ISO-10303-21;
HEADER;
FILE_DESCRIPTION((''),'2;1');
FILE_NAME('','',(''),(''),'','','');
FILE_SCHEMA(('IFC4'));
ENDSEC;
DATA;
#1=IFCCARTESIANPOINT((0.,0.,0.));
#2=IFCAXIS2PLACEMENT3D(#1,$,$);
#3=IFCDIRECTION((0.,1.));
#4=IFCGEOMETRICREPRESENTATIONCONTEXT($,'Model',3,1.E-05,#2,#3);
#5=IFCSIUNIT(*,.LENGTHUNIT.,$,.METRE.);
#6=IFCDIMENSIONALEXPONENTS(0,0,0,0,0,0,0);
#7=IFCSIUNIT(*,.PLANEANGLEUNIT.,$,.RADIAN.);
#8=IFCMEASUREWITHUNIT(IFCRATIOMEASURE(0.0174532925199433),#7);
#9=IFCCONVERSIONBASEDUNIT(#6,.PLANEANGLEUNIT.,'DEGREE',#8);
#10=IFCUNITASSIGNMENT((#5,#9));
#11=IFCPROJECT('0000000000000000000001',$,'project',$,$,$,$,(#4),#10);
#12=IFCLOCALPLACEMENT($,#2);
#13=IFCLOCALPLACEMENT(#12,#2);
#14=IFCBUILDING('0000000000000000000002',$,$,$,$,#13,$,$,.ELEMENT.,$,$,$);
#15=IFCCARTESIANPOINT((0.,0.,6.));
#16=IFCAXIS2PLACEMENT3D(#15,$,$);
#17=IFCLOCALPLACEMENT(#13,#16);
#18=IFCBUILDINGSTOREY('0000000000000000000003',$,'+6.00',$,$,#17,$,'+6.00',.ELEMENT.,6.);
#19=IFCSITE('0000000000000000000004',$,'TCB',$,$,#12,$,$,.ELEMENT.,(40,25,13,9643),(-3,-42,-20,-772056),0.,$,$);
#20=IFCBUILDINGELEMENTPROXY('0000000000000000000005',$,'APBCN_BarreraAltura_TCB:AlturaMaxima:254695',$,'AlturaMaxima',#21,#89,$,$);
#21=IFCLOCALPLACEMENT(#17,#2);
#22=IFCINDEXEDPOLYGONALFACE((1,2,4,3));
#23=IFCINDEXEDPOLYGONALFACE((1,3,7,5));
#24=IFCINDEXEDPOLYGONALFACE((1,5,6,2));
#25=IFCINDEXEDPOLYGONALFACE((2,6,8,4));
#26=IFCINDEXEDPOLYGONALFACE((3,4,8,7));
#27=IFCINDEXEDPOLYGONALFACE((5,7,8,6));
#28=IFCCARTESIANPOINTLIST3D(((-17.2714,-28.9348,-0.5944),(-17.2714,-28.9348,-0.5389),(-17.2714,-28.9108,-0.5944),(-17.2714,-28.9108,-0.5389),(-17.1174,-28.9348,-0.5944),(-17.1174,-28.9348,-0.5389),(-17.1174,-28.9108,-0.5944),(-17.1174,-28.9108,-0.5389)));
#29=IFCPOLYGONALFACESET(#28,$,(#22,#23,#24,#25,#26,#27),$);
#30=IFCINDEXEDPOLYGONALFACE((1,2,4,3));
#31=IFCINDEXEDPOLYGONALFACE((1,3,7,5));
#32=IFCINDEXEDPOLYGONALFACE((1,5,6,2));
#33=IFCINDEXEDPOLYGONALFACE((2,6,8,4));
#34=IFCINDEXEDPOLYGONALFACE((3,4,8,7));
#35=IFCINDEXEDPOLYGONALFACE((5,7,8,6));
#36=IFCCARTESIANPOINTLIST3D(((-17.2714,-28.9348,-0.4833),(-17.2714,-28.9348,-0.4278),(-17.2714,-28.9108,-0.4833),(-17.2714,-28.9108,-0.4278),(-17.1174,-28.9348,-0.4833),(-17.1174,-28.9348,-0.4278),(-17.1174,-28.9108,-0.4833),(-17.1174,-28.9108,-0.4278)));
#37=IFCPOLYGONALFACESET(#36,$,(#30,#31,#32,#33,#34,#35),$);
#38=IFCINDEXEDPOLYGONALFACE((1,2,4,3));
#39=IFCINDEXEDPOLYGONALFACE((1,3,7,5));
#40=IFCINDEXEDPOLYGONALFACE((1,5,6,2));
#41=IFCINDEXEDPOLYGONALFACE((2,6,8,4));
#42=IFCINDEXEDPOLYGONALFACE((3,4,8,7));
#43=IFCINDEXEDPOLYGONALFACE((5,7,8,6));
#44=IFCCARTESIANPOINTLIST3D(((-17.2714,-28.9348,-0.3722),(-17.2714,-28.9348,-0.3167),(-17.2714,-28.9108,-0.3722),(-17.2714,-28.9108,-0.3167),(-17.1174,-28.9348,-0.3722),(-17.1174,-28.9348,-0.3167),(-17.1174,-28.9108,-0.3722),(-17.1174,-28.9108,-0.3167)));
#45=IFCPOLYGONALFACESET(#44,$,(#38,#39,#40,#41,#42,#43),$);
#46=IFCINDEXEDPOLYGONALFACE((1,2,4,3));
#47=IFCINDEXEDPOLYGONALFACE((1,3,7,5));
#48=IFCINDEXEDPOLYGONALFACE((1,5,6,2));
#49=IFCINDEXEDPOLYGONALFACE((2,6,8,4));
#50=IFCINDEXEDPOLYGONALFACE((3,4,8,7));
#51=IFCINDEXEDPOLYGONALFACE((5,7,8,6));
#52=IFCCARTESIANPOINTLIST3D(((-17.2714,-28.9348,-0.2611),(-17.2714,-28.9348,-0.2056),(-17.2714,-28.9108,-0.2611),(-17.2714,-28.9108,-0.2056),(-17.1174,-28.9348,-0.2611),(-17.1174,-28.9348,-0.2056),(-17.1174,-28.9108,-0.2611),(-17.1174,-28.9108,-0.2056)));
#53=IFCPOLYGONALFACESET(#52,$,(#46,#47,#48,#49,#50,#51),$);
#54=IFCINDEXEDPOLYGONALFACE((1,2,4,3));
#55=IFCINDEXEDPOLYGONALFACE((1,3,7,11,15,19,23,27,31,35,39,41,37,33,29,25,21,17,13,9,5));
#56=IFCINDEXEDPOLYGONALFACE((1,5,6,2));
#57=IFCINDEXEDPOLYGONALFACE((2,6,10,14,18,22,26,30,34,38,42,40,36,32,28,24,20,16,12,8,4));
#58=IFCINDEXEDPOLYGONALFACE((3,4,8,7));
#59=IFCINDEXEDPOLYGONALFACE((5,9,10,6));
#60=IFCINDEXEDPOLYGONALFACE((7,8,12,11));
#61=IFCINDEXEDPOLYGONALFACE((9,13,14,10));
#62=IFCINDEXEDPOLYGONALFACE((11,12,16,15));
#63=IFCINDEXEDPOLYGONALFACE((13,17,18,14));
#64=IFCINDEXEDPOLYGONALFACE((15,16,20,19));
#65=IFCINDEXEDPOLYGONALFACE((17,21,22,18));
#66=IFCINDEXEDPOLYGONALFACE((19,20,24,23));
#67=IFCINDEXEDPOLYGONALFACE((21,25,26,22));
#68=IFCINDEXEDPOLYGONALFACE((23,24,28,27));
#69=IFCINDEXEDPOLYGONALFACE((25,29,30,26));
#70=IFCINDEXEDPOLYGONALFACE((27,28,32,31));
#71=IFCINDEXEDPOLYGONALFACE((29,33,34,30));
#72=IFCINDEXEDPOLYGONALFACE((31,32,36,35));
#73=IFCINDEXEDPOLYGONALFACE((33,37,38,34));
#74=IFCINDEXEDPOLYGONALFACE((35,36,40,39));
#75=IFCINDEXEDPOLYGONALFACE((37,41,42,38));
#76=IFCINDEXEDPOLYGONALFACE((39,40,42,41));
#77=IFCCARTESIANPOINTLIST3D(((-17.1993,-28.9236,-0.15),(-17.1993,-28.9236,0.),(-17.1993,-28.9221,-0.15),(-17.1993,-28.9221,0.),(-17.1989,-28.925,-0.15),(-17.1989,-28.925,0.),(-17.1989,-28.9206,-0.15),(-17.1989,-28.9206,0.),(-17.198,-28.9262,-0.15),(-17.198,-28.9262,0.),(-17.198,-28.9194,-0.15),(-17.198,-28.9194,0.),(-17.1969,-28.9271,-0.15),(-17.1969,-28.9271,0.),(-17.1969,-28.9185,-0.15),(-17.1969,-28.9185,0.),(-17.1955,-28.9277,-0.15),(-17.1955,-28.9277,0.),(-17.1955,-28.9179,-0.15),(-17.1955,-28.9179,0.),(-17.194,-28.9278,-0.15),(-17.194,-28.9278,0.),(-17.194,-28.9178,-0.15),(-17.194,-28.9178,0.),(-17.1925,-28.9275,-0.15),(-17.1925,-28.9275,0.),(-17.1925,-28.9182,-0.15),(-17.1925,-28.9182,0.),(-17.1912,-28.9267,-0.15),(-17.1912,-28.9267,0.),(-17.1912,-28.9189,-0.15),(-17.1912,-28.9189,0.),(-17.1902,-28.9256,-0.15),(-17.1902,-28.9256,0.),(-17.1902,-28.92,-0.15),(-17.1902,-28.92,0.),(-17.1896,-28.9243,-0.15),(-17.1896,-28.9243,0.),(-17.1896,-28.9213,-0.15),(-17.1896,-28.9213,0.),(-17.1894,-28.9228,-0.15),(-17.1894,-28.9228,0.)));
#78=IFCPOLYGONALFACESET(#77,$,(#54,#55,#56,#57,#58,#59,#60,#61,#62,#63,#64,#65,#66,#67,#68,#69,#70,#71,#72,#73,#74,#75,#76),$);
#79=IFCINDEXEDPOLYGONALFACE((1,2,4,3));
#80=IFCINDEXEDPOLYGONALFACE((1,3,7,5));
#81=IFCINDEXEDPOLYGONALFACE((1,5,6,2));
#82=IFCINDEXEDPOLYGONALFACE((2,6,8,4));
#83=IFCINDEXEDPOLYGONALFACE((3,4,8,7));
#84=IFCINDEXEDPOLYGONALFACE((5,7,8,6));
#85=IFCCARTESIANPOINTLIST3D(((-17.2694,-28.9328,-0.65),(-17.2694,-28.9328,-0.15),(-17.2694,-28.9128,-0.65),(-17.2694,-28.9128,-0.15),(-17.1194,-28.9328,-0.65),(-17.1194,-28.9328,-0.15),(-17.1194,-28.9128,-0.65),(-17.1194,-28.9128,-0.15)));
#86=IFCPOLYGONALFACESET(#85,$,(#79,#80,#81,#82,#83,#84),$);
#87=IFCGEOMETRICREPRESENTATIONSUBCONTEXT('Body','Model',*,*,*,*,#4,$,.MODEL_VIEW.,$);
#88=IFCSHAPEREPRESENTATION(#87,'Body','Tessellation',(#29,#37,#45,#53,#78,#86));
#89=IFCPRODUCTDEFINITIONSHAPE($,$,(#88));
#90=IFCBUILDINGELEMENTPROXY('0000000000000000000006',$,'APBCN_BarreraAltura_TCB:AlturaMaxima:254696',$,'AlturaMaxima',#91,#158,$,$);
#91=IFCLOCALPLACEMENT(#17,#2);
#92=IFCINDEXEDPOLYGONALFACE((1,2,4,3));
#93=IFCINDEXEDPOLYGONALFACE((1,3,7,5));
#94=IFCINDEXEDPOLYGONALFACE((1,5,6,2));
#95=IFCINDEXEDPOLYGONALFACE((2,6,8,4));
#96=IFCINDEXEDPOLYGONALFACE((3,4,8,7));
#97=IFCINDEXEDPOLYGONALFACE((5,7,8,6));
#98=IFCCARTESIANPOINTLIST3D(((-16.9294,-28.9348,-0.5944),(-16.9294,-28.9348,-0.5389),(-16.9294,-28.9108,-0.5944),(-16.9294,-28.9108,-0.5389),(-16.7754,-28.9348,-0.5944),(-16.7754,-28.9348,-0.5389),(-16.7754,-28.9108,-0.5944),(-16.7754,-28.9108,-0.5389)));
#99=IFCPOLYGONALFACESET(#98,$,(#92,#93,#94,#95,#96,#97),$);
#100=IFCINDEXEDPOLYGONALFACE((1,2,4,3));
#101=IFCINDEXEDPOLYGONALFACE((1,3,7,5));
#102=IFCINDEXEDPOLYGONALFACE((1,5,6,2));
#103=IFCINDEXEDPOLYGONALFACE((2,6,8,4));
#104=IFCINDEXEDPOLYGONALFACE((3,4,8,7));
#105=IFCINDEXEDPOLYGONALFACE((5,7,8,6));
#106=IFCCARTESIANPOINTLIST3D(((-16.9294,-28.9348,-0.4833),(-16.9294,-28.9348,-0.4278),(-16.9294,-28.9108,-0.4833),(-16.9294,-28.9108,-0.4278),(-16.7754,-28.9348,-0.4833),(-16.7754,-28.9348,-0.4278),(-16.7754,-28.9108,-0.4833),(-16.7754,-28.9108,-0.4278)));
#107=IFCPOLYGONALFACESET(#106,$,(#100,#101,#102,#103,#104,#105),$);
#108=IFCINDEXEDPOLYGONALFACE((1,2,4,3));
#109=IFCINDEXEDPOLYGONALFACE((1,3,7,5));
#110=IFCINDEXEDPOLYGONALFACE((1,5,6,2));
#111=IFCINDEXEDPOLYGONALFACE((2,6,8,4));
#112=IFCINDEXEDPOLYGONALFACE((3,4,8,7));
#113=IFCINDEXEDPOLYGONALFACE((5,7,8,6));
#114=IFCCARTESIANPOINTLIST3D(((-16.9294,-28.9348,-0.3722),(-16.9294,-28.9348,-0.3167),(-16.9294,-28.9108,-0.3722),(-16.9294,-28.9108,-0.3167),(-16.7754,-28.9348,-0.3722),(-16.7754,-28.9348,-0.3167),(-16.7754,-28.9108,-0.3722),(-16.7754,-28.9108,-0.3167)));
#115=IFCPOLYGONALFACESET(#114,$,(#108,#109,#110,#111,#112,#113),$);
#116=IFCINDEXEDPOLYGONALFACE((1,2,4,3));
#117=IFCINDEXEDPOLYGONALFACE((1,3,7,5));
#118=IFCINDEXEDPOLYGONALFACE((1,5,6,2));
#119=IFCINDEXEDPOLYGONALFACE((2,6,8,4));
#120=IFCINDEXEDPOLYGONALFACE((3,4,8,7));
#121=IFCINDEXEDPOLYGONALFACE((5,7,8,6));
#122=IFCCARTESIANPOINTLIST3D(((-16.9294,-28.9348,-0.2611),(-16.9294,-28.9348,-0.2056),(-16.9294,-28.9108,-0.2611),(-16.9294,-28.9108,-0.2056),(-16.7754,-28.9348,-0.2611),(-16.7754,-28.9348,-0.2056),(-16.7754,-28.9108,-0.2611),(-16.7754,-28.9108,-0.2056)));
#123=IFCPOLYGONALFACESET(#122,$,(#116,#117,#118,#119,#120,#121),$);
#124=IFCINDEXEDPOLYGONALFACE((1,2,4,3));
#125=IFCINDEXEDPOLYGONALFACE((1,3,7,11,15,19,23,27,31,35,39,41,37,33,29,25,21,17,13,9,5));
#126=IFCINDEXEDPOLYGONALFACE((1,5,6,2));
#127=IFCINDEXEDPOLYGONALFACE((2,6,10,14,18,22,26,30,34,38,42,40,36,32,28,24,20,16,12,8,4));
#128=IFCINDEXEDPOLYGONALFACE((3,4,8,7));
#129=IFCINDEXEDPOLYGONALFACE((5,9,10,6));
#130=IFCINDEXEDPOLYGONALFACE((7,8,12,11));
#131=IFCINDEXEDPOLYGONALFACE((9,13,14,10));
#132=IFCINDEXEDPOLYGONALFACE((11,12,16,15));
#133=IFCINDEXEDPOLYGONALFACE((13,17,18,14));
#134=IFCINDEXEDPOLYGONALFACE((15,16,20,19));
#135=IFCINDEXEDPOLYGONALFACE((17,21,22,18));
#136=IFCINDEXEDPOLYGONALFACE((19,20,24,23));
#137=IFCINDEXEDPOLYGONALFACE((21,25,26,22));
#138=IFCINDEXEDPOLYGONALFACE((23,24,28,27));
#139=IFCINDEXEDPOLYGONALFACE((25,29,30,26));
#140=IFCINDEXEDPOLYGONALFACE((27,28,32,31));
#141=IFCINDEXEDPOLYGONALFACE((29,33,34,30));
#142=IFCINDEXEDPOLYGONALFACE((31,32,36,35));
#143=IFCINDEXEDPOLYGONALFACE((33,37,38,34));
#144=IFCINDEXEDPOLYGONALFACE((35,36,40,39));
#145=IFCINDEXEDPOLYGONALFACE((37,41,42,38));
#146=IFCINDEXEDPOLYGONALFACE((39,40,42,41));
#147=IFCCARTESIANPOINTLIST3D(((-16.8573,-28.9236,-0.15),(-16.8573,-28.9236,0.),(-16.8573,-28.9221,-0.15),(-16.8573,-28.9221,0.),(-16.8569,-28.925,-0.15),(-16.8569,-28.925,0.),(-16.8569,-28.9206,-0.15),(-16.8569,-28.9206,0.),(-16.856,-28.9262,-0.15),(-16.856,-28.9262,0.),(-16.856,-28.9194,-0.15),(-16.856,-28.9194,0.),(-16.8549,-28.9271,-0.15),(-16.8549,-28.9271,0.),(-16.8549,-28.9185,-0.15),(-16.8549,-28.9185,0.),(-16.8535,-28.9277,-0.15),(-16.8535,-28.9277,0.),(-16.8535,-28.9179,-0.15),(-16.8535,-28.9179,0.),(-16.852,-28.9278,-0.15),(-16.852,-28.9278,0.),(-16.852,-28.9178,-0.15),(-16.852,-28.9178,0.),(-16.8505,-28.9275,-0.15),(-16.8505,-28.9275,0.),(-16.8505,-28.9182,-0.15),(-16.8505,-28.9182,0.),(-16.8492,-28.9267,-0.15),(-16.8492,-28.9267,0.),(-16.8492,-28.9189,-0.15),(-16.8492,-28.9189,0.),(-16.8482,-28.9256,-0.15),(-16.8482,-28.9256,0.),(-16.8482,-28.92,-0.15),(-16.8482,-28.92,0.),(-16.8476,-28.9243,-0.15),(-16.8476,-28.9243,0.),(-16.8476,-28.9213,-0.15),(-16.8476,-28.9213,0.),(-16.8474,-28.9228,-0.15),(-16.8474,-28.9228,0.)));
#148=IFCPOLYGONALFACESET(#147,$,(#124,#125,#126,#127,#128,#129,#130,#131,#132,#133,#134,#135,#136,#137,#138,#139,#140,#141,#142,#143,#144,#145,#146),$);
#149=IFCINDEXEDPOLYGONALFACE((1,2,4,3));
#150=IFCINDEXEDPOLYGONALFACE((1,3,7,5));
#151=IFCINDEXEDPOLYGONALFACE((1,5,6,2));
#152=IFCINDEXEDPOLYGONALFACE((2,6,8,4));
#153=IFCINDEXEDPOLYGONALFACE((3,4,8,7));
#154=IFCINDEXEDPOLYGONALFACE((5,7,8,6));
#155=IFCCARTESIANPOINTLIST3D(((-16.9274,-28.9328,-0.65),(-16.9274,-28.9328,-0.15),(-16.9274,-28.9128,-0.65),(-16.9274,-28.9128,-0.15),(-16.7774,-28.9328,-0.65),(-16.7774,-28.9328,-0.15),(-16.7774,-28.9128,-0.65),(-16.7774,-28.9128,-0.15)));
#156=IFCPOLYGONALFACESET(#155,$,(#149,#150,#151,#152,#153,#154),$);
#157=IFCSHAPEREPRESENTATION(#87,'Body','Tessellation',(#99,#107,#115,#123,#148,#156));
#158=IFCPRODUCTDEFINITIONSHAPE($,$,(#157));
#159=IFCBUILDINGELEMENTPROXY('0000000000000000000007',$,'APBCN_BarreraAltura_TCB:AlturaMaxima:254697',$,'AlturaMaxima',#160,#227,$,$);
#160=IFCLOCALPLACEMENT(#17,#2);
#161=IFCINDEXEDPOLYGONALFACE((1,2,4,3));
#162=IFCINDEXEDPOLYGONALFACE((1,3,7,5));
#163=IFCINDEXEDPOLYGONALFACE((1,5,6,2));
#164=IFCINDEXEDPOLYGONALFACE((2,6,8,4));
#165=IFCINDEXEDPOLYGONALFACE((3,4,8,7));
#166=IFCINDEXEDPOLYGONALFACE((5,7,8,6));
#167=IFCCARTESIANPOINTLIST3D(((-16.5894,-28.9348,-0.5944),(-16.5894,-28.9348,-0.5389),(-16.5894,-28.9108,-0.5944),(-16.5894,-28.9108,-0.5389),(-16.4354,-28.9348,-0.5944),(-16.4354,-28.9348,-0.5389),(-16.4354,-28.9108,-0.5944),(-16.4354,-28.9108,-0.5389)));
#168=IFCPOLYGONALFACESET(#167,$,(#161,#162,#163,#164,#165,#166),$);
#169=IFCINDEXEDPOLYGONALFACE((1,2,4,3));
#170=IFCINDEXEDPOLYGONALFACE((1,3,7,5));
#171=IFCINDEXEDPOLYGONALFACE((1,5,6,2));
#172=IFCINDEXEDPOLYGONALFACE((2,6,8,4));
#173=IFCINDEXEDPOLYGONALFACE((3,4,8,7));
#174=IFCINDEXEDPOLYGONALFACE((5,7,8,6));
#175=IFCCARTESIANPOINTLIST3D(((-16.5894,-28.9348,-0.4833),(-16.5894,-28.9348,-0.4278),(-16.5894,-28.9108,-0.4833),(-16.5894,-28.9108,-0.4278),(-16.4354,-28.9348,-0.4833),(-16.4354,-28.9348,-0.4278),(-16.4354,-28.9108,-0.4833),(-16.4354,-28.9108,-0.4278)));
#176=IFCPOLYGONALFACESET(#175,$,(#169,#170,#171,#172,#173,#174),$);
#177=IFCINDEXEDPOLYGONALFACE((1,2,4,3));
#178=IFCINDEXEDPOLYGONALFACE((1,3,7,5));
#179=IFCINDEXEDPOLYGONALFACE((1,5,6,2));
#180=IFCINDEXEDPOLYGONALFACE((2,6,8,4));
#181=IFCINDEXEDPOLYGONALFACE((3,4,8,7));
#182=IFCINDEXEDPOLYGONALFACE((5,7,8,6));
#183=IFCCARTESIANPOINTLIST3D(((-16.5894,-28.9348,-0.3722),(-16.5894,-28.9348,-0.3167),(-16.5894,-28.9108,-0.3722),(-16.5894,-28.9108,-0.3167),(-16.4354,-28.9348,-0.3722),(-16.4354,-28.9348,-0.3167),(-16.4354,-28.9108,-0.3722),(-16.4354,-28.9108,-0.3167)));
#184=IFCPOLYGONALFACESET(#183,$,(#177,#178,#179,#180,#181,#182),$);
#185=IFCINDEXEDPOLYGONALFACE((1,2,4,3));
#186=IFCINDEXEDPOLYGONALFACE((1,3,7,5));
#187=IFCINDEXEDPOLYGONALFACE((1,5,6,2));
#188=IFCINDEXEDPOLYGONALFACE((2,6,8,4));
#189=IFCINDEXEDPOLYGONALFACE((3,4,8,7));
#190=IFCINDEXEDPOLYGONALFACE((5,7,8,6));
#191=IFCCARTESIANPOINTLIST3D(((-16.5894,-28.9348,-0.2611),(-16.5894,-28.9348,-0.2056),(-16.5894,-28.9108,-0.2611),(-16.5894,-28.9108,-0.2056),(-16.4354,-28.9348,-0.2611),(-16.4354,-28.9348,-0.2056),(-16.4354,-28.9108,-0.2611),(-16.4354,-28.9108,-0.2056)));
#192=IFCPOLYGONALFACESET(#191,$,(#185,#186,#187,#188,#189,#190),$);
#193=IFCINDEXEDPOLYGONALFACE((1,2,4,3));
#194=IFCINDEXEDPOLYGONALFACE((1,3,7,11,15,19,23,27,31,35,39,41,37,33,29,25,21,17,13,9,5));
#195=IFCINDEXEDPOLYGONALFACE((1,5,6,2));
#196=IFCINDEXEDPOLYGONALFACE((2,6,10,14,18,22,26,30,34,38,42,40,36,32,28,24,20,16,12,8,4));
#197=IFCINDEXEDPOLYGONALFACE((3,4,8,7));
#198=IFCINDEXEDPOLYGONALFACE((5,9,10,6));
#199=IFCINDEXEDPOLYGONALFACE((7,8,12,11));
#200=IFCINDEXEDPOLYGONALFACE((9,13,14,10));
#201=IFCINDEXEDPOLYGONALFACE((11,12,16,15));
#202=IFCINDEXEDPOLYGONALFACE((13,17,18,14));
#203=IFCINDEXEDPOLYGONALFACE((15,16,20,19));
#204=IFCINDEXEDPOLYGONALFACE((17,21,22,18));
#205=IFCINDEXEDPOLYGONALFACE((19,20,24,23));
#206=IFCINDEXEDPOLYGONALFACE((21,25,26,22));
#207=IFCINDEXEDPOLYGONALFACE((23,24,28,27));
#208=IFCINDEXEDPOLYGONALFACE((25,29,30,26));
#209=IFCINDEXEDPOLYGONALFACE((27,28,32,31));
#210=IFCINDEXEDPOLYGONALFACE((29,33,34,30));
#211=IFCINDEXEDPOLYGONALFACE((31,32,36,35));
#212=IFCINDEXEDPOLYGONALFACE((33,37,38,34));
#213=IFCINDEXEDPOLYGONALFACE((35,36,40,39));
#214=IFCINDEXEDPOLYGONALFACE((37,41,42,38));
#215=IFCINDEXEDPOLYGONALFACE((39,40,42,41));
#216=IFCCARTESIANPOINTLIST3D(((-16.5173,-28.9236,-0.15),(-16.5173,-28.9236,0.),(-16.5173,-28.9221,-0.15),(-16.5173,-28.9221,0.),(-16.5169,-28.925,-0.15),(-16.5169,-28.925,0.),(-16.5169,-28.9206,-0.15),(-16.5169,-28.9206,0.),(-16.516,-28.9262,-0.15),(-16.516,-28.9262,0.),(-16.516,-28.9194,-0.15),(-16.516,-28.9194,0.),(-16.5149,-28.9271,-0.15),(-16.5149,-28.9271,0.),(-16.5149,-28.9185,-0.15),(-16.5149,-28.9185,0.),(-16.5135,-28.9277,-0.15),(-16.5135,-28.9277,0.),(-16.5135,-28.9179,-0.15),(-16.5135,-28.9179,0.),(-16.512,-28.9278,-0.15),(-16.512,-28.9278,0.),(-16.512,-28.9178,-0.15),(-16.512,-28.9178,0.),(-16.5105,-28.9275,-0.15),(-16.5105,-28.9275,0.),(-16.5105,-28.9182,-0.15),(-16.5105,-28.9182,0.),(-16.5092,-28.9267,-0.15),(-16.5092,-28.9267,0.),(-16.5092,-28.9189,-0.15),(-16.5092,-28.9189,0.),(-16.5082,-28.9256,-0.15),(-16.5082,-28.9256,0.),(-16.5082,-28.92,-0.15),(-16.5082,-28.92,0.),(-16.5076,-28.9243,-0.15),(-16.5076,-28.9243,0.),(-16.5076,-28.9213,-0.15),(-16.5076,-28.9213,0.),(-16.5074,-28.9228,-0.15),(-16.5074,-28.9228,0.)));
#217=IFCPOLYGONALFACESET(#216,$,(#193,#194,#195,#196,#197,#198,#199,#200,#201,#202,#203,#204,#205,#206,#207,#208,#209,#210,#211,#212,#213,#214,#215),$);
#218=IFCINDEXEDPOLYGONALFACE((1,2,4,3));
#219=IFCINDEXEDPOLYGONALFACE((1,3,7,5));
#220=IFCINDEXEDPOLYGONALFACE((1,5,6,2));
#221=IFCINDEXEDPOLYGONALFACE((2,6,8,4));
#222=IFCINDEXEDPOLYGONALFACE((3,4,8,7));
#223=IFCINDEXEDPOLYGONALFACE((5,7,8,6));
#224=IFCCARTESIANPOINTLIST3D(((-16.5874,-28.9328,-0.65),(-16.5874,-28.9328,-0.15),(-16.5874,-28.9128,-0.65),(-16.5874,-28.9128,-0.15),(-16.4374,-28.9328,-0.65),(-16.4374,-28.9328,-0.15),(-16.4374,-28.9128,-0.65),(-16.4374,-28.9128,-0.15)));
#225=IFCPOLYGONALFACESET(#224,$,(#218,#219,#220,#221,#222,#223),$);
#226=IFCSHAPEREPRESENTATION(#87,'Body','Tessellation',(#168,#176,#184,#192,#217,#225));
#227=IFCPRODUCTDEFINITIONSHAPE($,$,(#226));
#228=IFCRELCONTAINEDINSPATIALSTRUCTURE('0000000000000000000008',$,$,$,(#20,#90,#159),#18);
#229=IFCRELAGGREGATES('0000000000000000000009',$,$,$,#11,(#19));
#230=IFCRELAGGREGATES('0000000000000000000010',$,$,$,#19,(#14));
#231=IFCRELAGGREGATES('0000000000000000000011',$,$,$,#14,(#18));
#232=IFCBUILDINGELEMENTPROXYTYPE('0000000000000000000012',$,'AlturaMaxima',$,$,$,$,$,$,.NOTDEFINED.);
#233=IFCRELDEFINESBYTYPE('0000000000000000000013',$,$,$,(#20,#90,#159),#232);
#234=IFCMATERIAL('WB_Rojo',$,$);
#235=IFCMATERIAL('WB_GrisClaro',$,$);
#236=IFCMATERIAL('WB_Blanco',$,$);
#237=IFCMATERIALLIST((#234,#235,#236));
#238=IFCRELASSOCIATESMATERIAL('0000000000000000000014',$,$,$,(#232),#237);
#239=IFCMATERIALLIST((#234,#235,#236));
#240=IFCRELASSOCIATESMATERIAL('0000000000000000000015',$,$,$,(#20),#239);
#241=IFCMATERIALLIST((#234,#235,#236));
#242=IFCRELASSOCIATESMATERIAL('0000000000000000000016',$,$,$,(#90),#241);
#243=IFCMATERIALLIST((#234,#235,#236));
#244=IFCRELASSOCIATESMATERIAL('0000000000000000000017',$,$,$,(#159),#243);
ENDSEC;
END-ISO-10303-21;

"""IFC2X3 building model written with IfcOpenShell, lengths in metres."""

from ifc_helpers import new_model, entity, si_unit, converted_unit, direction, frame, frame_2d, origin, origin_2d_with_axis, place, context, subcontext, project, spatial, rectangle, circle, extrude, source, transform, mapped, material, material_list, type_object, type_shapes, element, save


model = new_model("IFC2X3")

# Units and contexts
model_context = context("Model", 3, precision=1e-05, world=origin(), true_north=direction((0.0, 1.0)))
body_context = subcontext(model_context, "Body", "Model", "MODEL_VIEW")
ifc_project = project(units=[si_unit("LENGTHUNIT", "METRE"), converted_unit("PLANEANGLEUNIT", "DEGREE", entity("IfcRatioMeasure", 0.0174532925199433), si_unit("PLANEANGLEUNIT", "RADIAN"), dimensions=[0, 0, 0, 0, 0, 0, 0])], contexts=[model_context])

# Site, building, storey
site_placement = place(None, origin())
site = spatial("IfcSite", under=ifc_project, at=site_placement, Name="TCB", CompositionType="ELEMENT", RefLatitude=(40, 25, 13, 9643), RefLongitude=(-3, -42, -20, -772056), RefElevation=0.0)
building_placement = place(site_placement, origin())
building = spatial("IfcBuilding", under=site, at=building_placement, CompositionType="ELEMENT")
storey_placement = place(building_placement, frame((0.0, 0.0, 6.0)))
storey = spatial("IfcBuildingStorey", under=building, at=storey_placement, Name="+6.00", LongName="+6.00", CompositionType="ELEMENT", Elevation=6.0)

# Building element proxies
ifc_material_1 = material(Name="WB_Rojo")
ifc_material_2 = material(Name="WB_GrisClaro")
ifc_material_3 = material(Name="WB_Blanco")
ifc_material_list_1 = material_list([ifc_material_1, ifc_material_2, ifc_material_3])
building_element_proxy_type = type_object("IfcBuildingElementProxyType", Name="AlturaMaxima", PredefinedType="NOTDEFINED", material=ifc_material_list_1)
shared_shape = source(origin(), body_context, "Body", "SweptSolid", [
    extrude(rectangle(XDim=0.154, YDim=0.024, at=frame_2d((0.0, 0.0), x_axis=(1.0, 0.0))), frame((0.0, 0.0, -0.5944), z_axis=(0.0, 0.0, 1.0), x_axis=(-1.0, 0.0, 0.0)), (0.0, 0.0, 1.0), 0.0556),
    extrude(rectangle(XDim=0.154, YDim=0.024, at=frame_2d((0.0, 0.0), x_axis=(1.0, 0.0))), frame((0.0, 0.0, -0.4833), z_axis=(0.0, 0.0, 1.0), x_axis=(-1.0, 0.0, 0.0)), (0.0, 0.0, 1.0), 0.0556),
    extrude(rectangle(XDim=0.154, YDim=0.024, at=frame_2d((0.0, 0.0), x_axis=(1.0, 0.0))), frame((0.0, 0.0, -0.3722), z_axis=(0.0, 0.0, 1.0), x_axis=(-1.0, 0.0, 0.0)), (0.0, 0.0, 1.0), 0.0556),
    extrude(rectangle(XDim=0.154, YDim=0.024, at=frame_2d((0.0, 0.0), x_axis=(1.0, 0.0))), frame((0.0, 0.0, -0.2611), z_axis=(0.0, 0.0, 1.0), x_axis=(-1.0, 0.0, 0.0)), (0.0, 0.0, 1.0), 0.0556),
    extrude(circle(Radius=0.005, at=frame_2d((0.0, 0.0), x_axis=(1.0, 0.0))), frame((0.0, 0.0, -0.15)), (0.0, 0.0, 1.0), 0.15),
    extrude(rectangle(XDim=0.02, YDim=0.15, at=origin_2d_with_axis()), frame((0.0, 0.0, -0.65), z_axis=(0.0, 0.0, 1.0), x_axis=(0.0, 1.0, 0.0)), (0.0, 0.0, 1.0), 0.5),
])
type_shapes(building_element_proxy_type, [shared_shape])
ifc_material_list_2 = material_list([ifc_material_1, ifc_material_2, ifc_material_3])
proxy_1_placement = place(storey_placement, frame((-17.1944, -28.9228, 0.0)))
element("IfcBuildingElementProxy", 1, at=proxy_1_placement, inside=storey, type_object=building_element_proxy_type, material=ifc_material_list_2, Name="APBCN_BarreraAltura_TCB:AlturaMaxima:254695", ObjectType="AlturaMaxima", context=body_context, shape_type="MappedRepresentation", body=[
    mapped(shared_shape, transform((0.0, 0.0, 0.0), scale=1.0)),
])
ifc_material_list_3 = material_list([ifc_material_1, ifc_material_2, ifc_material_3])
proxy_2_placement = place(storey_placement, frame((-16.8524, -28.9228, 0.0)))
element("IfcBuildingElementProxy", 2, at=proxy_2_placement, inside=storey, type_object=building_element_proxy_type, material=ifc_material_list_3, Name="APBCN_BarreraAltura_TCB:AlturaMaxima:254696", ObjectType="AlturaMaxima", context=body_context, shape_type="MappedRepresentation", body=[
    mapped(shared_shape, transform((0.0, 0.0, 0.0), scale=1.0)),
])
ifc_material_list_4 = material_list([ifc_material_1, ifc_material_2, ifc_material_3])
proxy_3_placement = place(storey_placement, frame((-16.5124, -28.9228, 0.0)))
element("IfcBuildingElementProxy", 3, at=proxy_3_placement, inside=storey, type_object=building_element_proxy_type, material=ifc_material_list_4, Name="APBCN_BarreraAltura_TCB:AlturaMaxima:254697", ObjectType="AlturaMaxima", context=body_context, shape_type="MappedRepresentation", body=[
    mapped(shared_shape, transform((0.0, 0.0, 0.0), scale=1.0)),
])

save(model, "model.ifc")
